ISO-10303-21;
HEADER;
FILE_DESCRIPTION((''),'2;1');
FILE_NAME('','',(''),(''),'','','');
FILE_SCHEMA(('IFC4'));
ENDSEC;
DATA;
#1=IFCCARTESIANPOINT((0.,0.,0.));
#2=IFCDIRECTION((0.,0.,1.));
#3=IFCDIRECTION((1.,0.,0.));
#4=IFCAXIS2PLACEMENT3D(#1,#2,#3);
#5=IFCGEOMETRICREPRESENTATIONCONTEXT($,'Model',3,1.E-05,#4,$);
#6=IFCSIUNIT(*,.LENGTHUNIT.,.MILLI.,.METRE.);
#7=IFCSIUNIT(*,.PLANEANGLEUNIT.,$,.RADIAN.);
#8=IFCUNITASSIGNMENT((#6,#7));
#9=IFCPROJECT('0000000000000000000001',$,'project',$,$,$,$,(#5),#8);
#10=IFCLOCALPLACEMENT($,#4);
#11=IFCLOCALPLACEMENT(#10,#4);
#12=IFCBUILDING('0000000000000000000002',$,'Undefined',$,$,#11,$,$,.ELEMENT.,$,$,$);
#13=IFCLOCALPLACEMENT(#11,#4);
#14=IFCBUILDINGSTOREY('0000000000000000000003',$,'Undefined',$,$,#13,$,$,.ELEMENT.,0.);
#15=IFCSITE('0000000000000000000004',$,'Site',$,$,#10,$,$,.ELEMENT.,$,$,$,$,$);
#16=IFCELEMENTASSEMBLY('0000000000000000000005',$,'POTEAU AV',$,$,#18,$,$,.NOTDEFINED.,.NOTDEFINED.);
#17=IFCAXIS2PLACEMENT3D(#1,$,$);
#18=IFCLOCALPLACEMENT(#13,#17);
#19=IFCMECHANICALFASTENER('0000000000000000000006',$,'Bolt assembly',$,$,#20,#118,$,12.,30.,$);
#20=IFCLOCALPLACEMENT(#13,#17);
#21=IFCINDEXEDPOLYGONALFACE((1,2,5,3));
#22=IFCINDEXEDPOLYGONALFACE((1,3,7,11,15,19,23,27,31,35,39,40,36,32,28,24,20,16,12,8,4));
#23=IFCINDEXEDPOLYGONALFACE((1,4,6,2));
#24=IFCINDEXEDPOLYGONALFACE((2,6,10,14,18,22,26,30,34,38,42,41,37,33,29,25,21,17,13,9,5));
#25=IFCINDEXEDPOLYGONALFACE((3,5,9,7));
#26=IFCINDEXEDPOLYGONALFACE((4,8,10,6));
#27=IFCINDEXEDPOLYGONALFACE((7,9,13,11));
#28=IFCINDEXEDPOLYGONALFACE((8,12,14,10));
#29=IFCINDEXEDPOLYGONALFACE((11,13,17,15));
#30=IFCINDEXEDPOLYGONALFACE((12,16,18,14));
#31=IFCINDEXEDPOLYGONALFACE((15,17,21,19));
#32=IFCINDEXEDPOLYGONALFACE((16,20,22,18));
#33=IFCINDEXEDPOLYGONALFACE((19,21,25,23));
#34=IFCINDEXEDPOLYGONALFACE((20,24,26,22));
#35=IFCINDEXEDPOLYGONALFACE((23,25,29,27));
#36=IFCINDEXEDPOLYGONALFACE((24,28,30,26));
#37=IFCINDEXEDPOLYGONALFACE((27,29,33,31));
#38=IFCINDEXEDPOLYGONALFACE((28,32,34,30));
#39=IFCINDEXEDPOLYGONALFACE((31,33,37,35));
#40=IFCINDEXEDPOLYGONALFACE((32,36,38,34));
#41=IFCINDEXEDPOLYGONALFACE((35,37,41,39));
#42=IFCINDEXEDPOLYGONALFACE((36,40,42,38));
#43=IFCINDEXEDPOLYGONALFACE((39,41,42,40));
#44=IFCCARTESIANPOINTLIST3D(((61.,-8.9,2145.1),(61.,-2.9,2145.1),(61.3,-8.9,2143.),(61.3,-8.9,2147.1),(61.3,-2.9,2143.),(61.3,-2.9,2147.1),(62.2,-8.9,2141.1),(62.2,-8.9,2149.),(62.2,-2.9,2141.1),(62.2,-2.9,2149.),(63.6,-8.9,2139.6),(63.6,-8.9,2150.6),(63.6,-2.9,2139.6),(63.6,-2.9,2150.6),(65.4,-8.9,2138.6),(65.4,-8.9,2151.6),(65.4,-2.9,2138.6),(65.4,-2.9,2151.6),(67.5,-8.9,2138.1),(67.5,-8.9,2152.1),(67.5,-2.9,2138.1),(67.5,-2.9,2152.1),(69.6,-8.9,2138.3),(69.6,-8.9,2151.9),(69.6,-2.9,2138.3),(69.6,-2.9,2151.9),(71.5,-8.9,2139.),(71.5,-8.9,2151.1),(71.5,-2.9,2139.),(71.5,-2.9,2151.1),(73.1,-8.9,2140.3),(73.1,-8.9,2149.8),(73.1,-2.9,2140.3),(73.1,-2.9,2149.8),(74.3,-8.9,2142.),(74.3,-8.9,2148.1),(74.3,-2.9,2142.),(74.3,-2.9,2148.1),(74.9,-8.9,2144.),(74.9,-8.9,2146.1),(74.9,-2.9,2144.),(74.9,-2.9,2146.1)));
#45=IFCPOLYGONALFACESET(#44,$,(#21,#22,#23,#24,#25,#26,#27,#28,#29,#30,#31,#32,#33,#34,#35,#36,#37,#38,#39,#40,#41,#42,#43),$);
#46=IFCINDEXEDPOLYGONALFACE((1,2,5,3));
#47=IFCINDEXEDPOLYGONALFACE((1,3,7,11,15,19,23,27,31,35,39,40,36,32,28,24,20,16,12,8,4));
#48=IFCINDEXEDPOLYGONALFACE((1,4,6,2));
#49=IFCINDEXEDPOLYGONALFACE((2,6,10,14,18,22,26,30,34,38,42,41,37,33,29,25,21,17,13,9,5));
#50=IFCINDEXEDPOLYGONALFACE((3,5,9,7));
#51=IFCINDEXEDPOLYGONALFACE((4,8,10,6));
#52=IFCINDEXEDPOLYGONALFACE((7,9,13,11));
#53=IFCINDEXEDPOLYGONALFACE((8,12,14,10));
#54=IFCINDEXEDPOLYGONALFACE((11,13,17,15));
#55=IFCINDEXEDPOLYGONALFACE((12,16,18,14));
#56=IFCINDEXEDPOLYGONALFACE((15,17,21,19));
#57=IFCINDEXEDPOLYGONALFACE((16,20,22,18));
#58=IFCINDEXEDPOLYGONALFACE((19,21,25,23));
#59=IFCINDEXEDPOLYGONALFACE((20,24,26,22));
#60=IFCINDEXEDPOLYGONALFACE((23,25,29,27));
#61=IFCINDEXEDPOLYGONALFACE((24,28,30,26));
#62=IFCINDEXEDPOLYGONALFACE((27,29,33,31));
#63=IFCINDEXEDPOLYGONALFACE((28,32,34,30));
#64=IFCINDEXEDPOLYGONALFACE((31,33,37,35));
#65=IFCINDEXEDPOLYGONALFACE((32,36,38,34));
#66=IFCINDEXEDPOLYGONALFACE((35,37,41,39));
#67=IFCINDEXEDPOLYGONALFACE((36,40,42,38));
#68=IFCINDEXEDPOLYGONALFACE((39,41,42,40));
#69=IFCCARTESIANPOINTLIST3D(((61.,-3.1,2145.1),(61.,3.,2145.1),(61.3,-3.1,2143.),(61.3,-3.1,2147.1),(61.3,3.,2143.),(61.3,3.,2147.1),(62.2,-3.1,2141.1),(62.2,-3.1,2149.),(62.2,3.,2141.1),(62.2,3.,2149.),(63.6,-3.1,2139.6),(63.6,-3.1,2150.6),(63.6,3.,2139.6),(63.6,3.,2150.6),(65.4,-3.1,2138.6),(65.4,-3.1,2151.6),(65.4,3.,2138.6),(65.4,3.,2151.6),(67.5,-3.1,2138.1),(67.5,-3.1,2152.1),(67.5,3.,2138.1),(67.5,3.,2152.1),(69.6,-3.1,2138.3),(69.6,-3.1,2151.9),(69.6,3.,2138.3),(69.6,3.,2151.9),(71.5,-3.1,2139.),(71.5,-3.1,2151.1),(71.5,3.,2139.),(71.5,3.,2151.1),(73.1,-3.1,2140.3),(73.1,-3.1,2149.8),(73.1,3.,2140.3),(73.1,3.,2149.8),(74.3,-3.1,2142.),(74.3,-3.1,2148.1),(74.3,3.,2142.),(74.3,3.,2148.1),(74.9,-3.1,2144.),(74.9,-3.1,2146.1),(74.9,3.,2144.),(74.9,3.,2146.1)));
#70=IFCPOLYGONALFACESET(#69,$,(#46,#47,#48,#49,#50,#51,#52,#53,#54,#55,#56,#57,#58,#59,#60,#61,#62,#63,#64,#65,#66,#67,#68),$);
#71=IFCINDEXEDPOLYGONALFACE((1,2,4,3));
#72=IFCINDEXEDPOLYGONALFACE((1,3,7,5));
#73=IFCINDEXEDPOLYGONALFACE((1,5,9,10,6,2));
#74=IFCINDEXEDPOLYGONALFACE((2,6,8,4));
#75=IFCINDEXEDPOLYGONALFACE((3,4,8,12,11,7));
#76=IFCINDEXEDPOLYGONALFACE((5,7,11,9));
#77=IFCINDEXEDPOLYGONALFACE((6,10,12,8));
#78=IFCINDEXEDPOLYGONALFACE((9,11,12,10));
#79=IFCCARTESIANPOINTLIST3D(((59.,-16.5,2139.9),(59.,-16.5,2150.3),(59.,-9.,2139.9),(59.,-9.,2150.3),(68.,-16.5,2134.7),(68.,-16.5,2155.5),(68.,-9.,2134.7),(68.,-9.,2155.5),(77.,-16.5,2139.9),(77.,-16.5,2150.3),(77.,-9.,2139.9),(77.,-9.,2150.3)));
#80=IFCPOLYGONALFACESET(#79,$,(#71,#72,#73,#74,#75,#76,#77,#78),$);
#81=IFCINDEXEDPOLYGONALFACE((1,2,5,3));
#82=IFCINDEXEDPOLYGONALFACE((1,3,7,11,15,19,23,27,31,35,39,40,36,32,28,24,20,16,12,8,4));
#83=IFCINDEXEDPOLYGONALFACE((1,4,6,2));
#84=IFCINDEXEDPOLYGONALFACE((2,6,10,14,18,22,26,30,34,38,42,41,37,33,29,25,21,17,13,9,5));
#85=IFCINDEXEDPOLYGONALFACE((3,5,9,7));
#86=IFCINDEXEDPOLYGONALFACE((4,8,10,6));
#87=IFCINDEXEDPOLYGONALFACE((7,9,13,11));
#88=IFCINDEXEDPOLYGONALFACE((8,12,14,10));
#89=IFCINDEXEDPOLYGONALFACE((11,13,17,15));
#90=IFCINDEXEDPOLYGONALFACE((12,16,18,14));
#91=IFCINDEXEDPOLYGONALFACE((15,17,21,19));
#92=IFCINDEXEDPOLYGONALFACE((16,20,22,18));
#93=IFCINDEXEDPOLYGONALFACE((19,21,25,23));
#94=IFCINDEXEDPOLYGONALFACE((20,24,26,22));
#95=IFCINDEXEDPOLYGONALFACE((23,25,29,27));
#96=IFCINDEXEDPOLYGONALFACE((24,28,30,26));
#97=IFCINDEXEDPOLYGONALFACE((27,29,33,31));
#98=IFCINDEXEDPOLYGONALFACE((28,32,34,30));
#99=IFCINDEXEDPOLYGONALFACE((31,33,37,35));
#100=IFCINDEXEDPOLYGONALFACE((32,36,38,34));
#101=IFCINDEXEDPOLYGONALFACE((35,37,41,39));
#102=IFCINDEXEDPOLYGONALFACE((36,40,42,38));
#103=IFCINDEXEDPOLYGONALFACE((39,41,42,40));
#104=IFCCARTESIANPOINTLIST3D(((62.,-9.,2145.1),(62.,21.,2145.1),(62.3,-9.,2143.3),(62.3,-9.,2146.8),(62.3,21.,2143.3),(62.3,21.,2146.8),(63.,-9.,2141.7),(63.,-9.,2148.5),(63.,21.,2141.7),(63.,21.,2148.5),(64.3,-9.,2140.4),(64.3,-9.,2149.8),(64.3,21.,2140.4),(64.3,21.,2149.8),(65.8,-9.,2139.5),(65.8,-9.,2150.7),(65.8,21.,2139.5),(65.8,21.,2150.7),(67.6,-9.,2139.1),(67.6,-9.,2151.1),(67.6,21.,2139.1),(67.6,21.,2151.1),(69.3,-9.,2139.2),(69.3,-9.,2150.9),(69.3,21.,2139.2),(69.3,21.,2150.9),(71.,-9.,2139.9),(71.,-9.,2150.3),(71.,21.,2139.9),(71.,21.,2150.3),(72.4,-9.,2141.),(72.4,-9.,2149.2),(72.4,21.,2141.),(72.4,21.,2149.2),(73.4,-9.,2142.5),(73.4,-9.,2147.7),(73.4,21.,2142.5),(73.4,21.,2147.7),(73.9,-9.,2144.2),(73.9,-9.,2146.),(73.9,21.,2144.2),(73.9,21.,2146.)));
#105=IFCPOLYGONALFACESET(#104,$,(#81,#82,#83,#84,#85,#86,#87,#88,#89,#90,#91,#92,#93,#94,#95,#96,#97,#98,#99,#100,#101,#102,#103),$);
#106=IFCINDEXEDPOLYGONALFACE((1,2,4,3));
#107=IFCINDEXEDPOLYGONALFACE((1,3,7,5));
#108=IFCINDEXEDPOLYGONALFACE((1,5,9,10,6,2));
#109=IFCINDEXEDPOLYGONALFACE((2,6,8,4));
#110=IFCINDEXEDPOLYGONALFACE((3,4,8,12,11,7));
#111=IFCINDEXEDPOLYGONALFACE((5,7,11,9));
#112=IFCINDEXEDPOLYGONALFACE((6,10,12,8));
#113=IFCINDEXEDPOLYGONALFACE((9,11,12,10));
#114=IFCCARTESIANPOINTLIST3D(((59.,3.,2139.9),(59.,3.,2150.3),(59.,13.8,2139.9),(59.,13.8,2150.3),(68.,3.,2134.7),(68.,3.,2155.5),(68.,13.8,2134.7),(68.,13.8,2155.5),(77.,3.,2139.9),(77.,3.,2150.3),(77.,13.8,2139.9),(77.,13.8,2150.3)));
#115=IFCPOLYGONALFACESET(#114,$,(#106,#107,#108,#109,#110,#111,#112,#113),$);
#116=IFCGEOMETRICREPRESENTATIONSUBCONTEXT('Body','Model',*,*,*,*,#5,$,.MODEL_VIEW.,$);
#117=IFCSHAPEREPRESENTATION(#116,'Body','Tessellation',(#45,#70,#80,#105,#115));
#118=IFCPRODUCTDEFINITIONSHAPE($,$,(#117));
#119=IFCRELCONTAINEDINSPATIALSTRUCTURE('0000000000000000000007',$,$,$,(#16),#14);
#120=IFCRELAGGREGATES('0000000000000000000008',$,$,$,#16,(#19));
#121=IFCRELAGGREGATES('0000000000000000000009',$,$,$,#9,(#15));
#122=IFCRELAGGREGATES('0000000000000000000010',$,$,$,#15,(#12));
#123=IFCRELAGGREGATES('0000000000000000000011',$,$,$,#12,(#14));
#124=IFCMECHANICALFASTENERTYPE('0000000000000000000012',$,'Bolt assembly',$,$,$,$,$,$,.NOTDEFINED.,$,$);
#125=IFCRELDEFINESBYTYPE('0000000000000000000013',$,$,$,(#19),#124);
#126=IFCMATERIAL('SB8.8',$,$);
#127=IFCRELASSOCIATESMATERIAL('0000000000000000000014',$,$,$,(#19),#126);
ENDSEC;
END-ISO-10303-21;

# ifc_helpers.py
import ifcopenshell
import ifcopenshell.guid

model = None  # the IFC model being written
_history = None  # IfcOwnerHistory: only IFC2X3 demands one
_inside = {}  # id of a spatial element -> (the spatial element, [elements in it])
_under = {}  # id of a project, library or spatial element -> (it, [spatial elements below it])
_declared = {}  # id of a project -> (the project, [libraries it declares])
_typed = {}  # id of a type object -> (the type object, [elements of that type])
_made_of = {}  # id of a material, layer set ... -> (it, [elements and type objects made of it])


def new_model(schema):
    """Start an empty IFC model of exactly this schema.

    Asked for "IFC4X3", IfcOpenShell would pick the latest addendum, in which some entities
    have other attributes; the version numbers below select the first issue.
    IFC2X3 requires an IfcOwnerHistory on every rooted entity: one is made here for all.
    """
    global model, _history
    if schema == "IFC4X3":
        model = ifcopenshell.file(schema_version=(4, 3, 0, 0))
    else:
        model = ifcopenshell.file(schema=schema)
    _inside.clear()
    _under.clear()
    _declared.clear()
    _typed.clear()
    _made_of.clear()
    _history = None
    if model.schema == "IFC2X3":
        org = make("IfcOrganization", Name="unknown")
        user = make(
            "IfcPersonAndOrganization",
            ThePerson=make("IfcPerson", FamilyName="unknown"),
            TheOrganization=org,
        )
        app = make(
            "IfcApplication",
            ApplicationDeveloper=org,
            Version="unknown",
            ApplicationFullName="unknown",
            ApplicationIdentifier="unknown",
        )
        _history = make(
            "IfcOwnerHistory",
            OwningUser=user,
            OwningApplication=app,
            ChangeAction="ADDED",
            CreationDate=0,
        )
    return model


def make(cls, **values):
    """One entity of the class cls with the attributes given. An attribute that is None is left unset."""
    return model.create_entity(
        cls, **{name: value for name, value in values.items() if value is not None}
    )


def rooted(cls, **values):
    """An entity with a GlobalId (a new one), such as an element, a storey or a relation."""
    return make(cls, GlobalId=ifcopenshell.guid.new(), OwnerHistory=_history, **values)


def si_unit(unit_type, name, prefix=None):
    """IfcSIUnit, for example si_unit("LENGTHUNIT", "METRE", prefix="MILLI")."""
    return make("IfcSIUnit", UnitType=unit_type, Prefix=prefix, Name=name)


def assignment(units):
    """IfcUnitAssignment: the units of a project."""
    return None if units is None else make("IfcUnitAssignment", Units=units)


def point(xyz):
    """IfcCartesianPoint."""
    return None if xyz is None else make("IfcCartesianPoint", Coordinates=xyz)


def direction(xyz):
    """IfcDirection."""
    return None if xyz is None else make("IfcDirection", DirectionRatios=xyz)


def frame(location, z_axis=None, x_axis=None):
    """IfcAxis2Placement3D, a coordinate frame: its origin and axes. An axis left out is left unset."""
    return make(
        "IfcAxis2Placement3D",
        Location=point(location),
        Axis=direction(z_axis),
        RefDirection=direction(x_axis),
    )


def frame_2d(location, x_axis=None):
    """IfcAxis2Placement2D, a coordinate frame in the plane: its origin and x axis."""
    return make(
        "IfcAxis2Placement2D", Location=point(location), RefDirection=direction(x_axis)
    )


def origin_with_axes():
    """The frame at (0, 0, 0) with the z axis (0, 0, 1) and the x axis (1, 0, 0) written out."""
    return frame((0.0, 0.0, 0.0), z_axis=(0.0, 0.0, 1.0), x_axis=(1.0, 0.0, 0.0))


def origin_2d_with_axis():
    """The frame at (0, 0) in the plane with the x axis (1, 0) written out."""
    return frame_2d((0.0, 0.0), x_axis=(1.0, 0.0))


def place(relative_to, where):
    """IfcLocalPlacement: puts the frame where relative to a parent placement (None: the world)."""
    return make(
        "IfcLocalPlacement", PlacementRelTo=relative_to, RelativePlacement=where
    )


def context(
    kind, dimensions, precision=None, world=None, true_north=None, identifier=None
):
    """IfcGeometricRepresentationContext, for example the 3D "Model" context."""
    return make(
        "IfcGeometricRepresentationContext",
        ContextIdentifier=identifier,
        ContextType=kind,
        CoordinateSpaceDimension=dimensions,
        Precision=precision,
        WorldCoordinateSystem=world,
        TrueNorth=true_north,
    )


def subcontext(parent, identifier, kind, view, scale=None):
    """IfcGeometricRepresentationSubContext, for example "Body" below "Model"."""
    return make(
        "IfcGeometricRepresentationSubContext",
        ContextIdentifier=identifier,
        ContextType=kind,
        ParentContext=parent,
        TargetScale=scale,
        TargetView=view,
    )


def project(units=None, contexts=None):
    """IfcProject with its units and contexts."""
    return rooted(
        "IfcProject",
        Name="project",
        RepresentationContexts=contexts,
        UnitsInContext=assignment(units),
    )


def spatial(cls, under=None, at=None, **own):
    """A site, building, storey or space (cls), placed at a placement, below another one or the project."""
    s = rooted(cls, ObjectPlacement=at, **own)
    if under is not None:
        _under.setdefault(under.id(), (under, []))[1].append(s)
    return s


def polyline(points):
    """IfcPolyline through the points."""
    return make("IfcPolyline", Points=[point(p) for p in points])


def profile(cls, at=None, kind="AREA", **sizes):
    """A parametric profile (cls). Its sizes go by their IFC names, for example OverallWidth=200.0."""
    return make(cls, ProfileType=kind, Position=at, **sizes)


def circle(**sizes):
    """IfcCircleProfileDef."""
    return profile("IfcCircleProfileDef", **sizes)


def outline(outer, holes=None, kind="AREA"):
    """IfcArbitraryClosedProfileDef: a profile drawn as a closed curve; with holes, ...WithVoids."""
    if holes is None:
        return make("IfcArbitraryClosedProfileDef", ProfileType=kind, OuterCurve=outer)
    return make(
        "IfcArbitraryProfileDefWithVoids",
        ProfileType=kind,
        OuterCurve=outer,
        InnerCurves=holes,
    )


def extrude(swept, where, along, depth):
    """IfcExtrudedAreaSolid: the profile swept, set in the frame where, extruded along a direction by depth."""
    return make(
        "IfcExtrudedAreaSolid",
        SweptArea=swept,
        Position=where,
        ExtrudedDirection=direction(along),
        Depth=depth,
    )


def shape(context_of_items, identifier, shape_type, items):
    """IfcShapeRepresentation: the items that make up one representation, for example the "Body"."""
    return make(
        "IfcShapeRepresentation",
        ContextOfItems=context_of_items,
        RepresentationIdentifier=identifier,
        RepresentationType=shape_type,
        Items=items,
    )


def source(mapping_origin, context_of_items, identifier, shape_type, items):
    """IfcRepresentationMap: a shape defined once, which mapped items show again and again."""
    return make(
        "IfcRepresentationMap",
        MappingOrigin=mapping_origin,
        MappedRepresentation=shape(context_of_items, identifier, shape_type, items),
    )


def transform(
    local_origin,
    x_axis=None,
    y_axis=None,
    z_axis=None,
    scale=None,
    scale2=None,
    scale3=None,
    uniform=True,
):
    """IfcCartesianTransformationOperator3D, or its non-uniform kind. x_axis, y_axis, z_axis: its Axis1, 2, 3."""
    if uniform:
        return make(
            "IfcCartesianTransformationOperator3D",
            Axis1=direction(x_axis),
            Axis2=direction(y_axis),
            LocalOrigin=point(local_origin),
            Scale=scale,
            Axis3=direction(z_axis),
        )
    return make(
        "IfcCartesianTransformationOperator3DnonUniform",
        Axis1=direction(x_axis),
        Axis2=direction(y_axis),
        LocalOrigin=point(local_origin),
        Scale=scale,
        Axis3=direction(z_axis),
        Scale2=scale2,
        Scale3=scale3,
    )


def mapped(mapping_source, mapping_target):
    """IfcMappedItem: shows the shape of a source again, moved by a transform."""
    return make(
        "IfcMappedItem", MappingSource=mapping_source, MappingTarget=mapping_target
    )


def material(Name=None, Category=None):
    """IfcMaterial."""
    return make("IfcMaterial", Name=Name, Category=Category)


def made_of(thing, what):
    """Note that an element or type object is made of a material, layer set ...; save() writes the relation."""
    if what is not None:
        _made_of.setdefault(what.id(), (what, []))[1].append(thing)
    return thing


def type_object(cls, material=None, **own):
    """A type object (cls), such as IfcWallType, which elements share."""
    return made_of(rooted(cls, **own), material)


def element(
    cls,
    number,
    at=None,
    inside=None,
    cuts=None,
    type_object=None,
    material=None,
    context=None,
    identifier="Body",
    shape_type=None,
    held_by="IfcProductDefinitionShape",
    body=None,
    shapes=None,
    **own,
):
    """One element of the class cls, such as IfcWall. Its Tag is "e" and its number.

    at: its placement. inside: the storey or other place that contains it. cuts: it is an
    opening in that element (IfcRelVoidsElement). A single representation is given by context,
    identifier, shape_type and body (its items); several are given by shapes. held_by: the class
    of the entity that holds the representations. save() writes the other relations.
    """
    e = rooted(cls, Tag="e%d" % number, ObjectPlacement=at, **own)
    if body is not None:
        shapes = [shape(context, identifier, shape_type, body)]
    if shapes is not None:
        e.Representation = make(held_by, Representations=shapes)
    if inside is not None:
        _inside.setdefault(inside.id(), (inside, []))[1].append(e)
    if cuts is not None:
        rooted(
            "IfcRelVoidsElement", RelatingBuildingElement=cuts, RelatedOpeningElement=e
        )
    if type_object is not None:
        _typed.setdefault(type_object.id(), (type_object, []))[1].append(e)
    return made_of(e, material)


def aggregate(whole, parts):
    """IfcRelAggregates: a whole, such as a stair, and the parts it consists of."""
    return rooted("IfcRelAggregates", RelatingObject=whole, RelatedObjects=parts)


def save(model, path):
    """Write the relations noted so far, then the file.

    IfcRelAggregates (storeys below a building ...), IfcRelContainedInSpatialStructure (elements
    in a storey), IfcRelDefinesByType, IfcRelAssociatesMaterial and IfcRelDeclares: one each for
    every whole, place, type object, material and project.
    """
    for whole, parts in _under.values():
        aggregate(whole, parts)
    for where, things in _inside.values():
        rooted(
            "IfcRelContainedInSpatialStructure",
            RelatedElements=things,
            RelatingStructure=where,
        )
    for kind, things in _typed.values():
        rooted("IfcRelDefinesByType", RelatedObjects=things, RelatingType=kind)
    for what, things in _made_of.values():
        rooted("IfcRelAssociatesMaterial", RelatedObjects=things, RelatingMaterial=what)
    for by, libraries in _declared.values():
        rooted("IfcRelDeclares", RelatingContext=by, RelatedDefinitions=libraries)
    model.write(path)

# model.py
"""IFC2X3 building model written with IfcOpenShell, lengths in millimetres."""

from ifc_helpers import new_model, si_unit, frame, origin_with_axes, origin_2d_with_axis, place, context, subcontext, project, spatial, polyline, circle, outline, extrude, source, transform, mapped, material, type_object, element, aggregate, save


model = new_model("IFC2X3")

# Units and contexts
model_context = context("Model", 3, precision=1e-05, world=origin_with_axes())
body_context = subcontext(model_context, "Body", "Model", "MODEL_VIEW")
ifc_project = project(units=[si_unit("LENGTHUNIT", "METRE", prefix="MILLI"), si_unit("PLANEANGLEUNIT", "RADIAN")], contexts=[model_context])

# Site, building, storey
site_placement = place(None, origin_with_axes())
site = spatial("IfcSite", under=ifc_project, at=site_placement, Name="Site", CompositionType="ELEMENT")
building_placement = place(site_placement, origin_with_axes())
building = spatial("IfcBuilding", under=site, at=building_placement, Name="Undefined", CompositionType="ELEMENT")
storey_placement = place(building_placement, origin_with_axes())
storey = spatial("IfcBuildingStorey", under=building, at=storey_placement, Name="Undefined", CompositionType="ELEMENT", Elevation=0.0)

# Element assembly
assembly_1_placement = place(storey_placement, origin_with_axes())
assembly_1 = element("IfcElementAssembly", 1, at=assembly_1_placement, inside=storey, Name="POTEAU AV", AssemblyPlace="NOTDEFINED", PredefinedType="NOTDEFINED")

# Mechanical fastener
ifc_material_1 = material(Name="SB8.8")
mechanical_fastener_type = type_object("IfcMechanicalFastenerType", Name="Bolt assembly")
shared_shape_1 = source(origin_with_axes(), body_context, "Body", "SweptSolid", [
    extrude(circle(Radius=7.0, at=origin_2d_with_axis()), frame((0.0, -8.9, 0.0), z_axis=(0.0, 1.0, 0.0), x_axis=(1.0, 0.0, 0.0)), (0.0, 0.0, 1.0), 6.0),
    extrude(circle(Radius=7.0, at=origin_2d_with_axis()), frame((0.0, -3.1, 0.0), z_axis=(0.0, 1.0, 0.0), x_axis=(1.0, 0.0, 0.0)), (0.0, 0.0, 1.0), 6.1),
    extrude(outline(polyline([(9.0, -5.2), (9.0, 5.2), (0.0, 10.4), (-9.0, 5.2), (-9.0, -5.2), (0.0, -10.4), (9.0, -5.2)])), frame((0.0, -16.5, 0.0), z_axis=(0.0, 1.0, 0.0), x_axis=(1.0, 0.0, 0.0)), (0.0, 0.0, 1.0), 7.5),
    extrude(circle(Radius=6.0, at=origin_2d_with_axis()), frame((0.0, -9.0, 0.0), z_axis=(0.0, 1.0, 0.0), x_axis=(1.0, 0.0, 0.0)), (0.0, 0.0, 1.0), 30.0),
    extrude(outline(polyline([(9.0, -5.2), (9.0, 5.2), (0.0, 10.4), (-9.0, 5.2), (-9.0, -5.2), (0.0, -10.4), (9.0, -5.2)])), frame((0.0, 3.0, 0.0), z_axis=(0.0, 1.0, 0.0), x_axis=(1.0, 0.0, 0.0)), (0.0, 0.0, 1.0), 10.8),
])
mechanical_fastener_1_placement = place(assembly_1_placement, frame((68.0, 0.0, 2145.1), z_axis=(0.0, 0.0, -1.0), x_axis=(-1.0, 0.0, 0.0)))
mechanical_fastener_1 = element("IfcMechanicalFastener", 2, at=mechanical_fastener_1_placement, type_object=mechanical_fastener_type, material=ifc_material_1, Name="Bolt assembly", NominalDiameter=12.0, NominalLength=30.0, context=body_context, shape_type="MappedRepresentation", body=[
    mapped(shared_shape_1, transform((0.0, 0.0, 0.0))),
])

aggregate(assembly_1, [mechanical_fastener_1])

save(model, "model.ifc")
